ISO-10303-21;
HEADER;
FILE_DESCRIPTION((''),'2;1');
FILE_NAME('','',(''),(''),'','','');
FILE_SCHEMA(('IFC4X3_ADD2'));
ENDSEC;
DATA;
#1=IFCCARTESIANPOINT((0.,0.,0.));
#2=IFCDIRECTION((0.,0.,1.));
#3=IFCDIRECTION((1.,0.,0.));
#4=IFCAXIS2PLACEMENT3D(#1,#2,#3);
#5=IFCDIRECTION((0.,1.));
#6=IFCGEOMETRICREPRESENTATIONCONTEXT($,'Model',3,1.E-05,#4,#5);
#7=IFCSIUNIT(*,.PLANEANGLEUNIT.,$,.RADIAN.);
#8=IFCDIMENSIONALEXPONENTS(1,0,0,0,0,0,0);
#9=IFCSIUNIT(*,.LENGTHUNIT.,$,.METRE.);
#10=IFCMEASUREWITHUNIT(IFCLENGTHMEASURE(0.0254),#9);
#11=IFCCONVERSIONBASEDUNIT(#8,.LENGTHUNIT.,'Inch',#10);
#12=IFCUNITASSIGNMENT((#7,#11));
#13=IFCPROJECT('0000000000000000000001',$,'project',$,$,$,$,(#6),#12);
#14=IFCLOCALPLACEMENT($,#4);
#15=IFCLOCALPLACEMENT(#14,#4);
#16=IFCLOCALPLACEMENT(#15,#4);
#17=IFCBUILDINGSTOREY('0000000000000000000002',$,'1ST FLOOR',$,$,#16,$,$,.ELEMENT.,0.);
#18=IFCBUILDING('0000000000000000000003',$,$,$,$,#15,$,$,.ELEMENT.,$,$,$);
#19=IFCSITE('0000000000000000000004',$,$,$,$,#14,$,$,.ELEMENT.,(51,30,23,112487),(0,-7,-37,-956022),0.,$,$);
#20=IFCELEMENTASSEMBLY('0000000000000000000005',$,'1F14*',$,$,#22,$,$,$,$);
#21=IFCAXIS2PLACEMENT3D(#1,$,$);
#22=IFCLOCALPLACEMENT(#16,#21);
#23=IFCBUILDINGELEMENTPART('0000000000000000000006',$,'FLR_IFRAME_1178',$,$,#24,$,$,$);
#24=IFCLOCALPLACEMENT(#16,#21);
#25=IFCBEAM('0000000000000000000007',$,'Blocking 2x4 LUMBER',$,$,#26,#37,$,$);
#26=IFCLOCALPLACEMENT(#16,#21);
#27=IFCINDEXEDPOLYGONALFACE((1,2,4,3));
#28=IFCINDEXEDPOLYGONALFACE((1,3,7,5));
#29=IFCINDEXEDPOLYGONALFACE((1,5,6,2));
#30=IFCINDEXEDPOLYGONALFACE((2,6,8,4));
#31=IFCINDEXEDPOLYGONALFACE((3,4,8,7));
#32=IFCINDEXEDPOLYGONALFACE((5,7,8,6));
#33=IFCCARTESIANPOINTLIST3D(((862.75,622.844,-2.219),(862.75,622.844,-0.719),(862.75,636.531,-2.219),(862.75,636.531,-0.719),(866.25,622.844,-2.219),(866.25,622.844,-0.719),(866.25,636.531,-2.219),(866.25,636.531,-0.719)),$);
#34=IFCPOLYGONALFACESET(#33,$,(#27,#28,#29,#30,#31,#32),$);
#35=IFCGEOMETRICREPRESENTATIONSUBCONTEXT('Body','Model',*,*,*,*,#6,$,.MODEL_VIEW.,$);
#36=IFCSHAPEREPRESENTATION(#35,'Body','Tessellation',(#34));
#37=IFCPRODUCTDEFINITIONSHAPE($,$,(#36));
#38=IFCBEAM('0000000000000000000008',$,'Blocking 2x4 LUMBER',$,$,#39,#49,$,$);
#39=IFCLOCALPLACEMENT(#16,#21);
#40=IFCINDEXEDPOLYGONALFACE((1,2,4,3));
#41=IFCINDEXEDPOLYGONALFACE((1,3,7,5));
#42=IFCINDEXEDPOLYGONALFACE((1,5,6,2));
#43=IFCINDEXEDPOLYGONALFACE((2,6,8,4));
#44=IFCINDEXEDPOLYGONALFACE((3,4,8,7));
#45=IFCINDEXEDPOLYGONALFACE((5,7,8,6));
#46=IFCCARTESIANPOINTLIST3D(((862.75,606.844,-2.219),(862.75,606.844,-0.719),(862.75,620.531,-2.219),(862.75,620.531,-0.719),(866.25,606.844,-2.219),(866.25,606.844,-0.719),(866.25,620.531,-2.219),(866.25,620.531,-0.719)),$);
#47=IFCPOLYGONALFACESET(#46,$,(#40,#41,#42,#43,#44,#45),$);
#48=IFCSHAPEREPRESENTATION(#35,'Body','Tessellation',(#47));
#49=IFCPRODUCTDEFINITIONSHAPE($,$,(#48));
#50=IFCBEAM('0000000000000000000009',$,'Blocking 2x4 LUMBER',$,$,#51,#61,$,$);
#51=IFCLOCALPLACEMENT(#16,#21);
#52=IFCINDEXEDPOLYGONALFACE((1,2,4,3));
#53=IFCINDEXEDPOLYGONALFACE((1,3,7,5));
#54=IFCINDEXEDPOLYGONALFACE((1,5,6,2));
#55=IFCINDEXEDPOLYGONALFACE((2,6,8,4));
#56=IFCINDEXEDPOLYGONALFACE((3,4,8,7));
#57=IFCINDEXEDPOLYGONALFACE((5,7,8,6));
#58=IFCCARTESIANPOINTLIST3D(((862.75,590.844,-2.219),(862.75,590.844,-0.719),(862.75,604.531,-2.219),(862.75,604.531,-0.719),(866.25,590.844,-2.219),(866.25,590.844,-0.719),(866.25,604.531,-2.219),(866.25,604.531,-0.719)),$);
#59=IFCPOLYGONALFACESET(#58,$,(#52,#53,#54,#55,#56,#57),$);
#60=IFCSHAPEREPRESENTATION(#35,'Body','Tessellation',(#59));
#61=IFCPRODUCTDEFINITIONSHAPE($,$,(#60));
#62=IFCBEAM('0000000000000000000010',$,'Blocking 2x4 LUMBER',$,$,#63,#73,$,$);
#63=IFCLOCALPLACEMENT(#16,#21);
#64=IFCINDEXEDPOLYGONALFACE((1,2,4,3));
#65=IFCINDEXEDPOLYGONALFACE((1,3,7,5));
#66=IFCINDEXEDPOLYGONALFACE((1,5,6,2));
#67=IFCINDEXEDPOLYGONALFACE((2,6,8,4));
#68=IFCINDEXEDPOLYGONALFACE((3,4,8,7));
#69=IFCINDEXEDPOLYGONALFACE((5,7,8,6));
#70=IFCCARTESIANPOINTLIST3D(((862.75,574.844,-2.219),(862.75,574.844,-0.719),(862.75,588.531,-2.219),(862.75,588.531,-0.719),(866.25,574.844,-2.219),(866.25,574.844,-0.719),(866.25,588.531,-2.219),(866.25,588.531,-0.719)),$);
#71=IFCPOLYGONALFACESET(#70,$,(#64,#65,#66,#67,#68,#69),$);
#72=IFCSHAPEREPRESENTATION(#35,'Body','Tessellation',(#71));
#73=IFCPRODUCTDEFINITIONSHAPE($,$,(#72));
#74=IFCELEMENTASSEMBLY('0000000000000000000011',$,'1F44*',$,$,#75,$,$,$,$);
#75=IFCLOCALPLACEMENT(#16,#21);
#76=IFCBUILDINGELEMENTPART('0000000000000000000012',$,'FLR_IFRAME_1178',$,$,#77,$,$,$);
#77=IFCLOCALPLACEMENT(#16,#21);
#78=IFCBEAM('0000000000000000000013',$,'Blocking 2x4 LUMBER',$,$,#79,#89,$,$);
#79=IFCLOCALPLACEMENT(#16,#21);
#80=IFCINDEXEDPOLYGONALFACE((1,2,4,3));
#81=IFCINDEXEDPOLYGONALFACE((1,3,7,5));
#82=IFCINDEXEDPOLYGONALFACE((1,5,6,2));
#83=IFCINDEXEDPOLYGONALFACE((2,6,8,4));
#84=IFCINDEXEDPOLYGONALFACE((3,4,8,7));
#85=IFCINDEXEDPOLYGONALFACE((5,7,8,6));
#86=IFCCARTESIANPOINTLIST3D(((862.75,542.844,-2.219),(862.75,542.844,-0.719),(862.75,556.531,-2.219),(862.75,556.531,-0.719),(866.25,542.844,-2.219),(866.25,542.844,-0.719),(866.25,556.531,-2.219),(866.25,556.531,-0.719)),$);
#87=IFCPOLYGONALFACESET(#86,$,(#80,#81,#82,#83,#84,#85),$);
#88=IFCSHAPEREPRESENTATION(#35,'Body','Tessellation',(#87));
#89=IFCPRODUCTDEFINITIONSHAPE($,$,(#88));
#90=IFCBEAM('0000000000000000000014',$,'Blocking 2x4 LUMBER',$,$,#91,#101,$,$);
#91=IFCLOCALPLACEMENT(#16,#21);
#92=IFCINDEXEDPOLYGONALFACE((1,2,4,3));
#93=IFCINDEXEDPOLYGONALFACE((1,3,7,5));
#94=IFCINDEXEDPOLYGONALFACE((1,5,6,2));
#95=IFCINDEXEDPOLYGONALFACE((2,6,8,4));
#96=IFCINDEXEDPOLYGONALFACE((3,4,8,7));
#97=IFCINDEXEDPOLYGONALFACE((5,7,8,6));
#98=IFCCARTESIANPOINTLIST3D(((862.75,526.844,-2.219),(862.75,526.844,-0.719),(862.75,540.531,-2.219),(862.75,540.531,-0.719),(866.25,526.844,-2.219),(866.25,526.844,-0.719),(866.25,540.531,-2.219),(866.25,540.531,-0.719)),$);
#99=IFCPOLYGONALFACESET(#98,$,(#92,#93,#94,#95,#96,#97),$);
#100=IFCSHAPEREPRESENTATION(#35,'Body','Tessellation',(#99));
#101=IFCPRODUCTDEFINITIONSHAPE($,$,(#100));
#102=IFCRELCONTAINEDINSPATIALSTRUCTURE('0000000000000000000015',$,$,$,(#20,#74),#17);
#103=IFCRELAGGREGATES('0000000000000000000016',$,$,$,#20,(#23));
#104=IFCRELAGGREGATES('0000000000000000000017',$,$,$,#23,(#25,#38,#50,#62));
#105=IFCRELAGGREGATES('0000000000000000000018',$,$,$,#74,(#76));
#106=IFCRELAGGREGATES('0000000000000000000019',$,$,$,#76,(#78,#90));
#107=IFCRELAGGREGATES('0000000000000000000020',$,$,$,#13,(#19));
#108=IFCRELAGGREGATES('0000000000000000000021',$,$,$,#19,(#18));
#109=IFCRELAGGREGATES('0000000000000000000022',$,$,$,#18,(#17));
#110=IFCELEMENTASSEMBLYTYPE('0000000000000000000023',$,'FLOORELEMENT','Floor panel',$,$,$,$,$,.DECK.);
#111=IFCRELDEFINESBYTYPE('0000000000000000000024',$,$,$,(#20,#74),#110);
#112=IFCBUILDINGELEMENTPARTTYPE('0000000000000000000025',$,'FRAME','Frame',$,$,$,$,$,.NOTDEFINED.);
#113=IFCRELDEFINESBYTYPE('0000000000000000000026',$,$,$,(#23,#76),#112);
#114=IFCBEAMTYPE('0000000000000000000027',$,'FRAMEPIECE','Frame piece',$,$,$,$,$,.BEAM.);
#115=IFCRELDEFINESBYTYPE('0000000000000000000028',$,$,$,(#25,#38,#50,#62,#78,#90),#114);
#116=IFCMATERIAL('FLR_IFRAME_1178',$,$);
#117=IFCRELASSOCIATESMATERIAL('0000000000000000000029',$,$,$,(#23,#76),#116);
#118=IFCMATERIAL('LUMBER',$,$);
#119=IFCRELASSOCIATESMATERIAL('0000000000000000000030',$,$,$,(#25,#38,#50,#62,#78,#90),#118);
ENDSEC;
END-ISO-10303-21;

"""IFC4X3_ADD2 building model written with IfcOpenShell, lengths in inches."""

from ifc_helpers import new_model, entity, si_unit, converted_unit, direction, frame, origin_with_axes, origin_2d_with_axis, place, context, subcontext, project, spatial, rectangle, extrude, material, type_object, element, aggregate, save


model = new_model("IFC4X3_ADD2")

# Units and contexts
model_context = context("Model", 3, precision=1e-05, world=origin_with_axes(), true_north=direction((0.0, 1.0)))
body_context = subcontext(model_context, "Body", "Model", "MODEL_VIEW")
ifc_project = project(units=[si_unit("PLANEANGLEUNIT", "RADIAN"), converted_unit("LENGTHUNIT", "Inch", entity("IfcLengthMeasure", 0.0254), si_unit("LENGTHUNIT", "METRE"), dimensions=[1, 0, 0, 0, 0, 0, 0])], contexts=[model_context])

# Site, building, storey
site_placement = place(None, origin_with_axes())
site = spatial("IfcSite", under=ifc_project, at=site_placement, CompositionType="ELEMENT", RefLatitude=(51, 30, 23, 112487), RefLongitude=(0, -7, -37, -956022), RefElevation=0.0)
building_placement = place(site_placement, origin_with_axes())
building = spatial("IfcBuilding", under=site, at=building_placement, CompositionType="ELEMENT")
storey_placement = place(building_placement, origin_with_axes())
storey = spatial("IfcBuildingStorey", under=building, at=storey_placement, Name="1ST FLOOR", CompositionType="ELEMENT", Elevation=0.0)

# Shared definitions
building_element_part_type = type_object("IfcBuildingElementPartType", Name="FRAME", Description="Frame", PredefinedType="NOTDEFINED")
ifc_material_1 = material(Name="LUMBER")

# Element assemblies, building element parts, beams
element_assembly_type_1 = type_object("IfcElementAssemblyType", Name="FLOORELEMENT", Description="Floor panel", PredefinedType="DECK")
assembly_1_placement = place(storey_placement, origin_with_axes())
assembly_1 = element("IfcElementAssembly", 1, at=assembly_1_placement, inside=storey, type_object=element_assembly_type_1, Name="1F14*")
ifc_material_2 = material(Name="FLR_IFRAME_1178")
building_element_part_1_placement = place(storey_placement, origin_with_axes())
building_element_part_1 = element("IfcBuildingElementPart", 2, at=building_element_part_1_placement, type_object=building_element_part_type, material=ifc_material_2, Name="FLR_IFRAME_1178")
aggregate(assembly_1, [building_element_part_1])
beam_type = type_object("IfcBeamType", Name="FRAMEPIECE", Description="Frame piece", PredefinedType="BEAM")
beam_1_placement = place(storey_placement, frame((864.5, 636.531, -1.469), z_axis=(0.0, -1.0, 0.0), x_axis=(0.0, 0.0, 1.0)))
beam_1 = element("IfcBeam", 3, at=beam_1_placement, type_object=beam_type, material=ifc_material_1, Name="Blocking 2x4 LUMBER", context=body_context, shape_type="SweptSolid", body=[
    extrude(rectangle(XDim=1.5, YDim=3.5, at=origin_2d_with_axis()), origin_with_axes(), (0.0, 0.0, 1.0), 13.688),
])
beam_2_placement = place(storey_placement, frame((864.5, 620.531, -1.469), z_axis=(0.0, -1.0, 0.0), x_axis=(0.0, 0.0, 1.0)))
beam_2 = element("IfcBeam", 4, at=beam_2_placement, type_object=beam_type, material=ifc_material_1, Name="Blocking 2x4 LUMBER", context=body_context, shape_type="SweptSolid", body=[
    extrude(rectangle(XDim=1.5, YDim=3.5, at=origin_2d_with_axis()), origin_with_axes(), (0.0, 0.0, 1.0), 13.688),
])
beam_3_placement = place(storey_placement, frame((864.5, 604.531, -1.469), z_axis=(0.0, -1.0, 0.0), x_axis=(0.0, 0.0, 1.0)))
beam_3 = element("IfcBeam", 5, at=beam_3_placement, type_object=beam_type, material=ifc_material_1, Name="Blocking 2x4 LUMBER", context=body_context, shape_type="SweptSolid", body=[
    extrude(rectangle(XDim=1.5, YDim=3.5, at=origin_2d_with_axis()), origin_with_axes(), (0.0, 0.0, 1.0), 13.688),
])
beam_4_placement = place(storey_placement, frame((864.5, 588.531, -1.469), z_axis=(0.0, -1.0, 0.0), x_axis=(0.0, 0.0, 1.0)))
beam_4 = element("IfcBeam", 6, at=beam_4_placement, type_object=beam_type, material=ifc_material_1, Name="Blocking 2x4 LUMBER", context=body_context, shape_type="SweptSolid", body=[
    extrude(rectangle(XDim=1.5, YDim=3.5, at=origin_2d_with_axis()), origin_with_axes(), (0.0, 0.0, 1.0), 13.688),
])
aggregate(building_element_part_1, [beam_1, beam_2, beam_3, beam_4])
assembly_2_placement = place(storey_placement, origin_with_axes())
assembly_2 = element("IfcElementAssembly", 7, at=assembly_2_placement, inside=storey, type_object=element_assembly_type_1, Name="1F44*")
building_element_part_2_placement = place(storey_placement, origin_with_axes())
building_element_part_2 = element("IfcBuildingElementPart", 8, at=building_element_part_2_placement, type_object=building_element_part_type, material=ifc_material_2, Name="FLR_IFRAME_1178")
aggregate(assembly_2, [building_element_part_2])
beam_5_placement = place(storey_placement, frame((864.5, 556.531, -1.469), z_axis=(0.0, -1.0, 0.0), x_axis=(0.0, 0.0, 1.0)))
beam_5 = element("IfcBeam", 9, at=beam_5_placement, type_object=beam_type, material=ifc_material_1, Name="Blocking 2x4 LUMBER", context=body_context, shape_type="SweptSolid", body=[
    extrude(rectangle(XDim=1.5, YDim=3.5, at=origin_2d_with_axis()), origin_with_axes(), (0.0, 0.0, 1.0), 13.688),
])
beam_6_placement = place(storey_placement, frame((864.5, 540.531, -1.469), z_axis=(0.0, -1.0, 0.0), x_axis=(0.0, 0.0, 1.0)))
beam_6 = element("IfcBeam", 10, at=beam_6_placement, type_object=beam_type, material=ifc_material_1, Name="Blocking 2x4 LUMBER", context=body_context, shape_type="SweptSolid", body=[
    extrude(rectangle(XDim=1.5, YDim=3.5, at=origin_2d_with_axis()), origin_with_axes(), (0.0, 0.0, 1.0), 13.688),
])
aggregate(building_element_part_2, [beam_5, beam_6])

save(model, "model.ifc")
